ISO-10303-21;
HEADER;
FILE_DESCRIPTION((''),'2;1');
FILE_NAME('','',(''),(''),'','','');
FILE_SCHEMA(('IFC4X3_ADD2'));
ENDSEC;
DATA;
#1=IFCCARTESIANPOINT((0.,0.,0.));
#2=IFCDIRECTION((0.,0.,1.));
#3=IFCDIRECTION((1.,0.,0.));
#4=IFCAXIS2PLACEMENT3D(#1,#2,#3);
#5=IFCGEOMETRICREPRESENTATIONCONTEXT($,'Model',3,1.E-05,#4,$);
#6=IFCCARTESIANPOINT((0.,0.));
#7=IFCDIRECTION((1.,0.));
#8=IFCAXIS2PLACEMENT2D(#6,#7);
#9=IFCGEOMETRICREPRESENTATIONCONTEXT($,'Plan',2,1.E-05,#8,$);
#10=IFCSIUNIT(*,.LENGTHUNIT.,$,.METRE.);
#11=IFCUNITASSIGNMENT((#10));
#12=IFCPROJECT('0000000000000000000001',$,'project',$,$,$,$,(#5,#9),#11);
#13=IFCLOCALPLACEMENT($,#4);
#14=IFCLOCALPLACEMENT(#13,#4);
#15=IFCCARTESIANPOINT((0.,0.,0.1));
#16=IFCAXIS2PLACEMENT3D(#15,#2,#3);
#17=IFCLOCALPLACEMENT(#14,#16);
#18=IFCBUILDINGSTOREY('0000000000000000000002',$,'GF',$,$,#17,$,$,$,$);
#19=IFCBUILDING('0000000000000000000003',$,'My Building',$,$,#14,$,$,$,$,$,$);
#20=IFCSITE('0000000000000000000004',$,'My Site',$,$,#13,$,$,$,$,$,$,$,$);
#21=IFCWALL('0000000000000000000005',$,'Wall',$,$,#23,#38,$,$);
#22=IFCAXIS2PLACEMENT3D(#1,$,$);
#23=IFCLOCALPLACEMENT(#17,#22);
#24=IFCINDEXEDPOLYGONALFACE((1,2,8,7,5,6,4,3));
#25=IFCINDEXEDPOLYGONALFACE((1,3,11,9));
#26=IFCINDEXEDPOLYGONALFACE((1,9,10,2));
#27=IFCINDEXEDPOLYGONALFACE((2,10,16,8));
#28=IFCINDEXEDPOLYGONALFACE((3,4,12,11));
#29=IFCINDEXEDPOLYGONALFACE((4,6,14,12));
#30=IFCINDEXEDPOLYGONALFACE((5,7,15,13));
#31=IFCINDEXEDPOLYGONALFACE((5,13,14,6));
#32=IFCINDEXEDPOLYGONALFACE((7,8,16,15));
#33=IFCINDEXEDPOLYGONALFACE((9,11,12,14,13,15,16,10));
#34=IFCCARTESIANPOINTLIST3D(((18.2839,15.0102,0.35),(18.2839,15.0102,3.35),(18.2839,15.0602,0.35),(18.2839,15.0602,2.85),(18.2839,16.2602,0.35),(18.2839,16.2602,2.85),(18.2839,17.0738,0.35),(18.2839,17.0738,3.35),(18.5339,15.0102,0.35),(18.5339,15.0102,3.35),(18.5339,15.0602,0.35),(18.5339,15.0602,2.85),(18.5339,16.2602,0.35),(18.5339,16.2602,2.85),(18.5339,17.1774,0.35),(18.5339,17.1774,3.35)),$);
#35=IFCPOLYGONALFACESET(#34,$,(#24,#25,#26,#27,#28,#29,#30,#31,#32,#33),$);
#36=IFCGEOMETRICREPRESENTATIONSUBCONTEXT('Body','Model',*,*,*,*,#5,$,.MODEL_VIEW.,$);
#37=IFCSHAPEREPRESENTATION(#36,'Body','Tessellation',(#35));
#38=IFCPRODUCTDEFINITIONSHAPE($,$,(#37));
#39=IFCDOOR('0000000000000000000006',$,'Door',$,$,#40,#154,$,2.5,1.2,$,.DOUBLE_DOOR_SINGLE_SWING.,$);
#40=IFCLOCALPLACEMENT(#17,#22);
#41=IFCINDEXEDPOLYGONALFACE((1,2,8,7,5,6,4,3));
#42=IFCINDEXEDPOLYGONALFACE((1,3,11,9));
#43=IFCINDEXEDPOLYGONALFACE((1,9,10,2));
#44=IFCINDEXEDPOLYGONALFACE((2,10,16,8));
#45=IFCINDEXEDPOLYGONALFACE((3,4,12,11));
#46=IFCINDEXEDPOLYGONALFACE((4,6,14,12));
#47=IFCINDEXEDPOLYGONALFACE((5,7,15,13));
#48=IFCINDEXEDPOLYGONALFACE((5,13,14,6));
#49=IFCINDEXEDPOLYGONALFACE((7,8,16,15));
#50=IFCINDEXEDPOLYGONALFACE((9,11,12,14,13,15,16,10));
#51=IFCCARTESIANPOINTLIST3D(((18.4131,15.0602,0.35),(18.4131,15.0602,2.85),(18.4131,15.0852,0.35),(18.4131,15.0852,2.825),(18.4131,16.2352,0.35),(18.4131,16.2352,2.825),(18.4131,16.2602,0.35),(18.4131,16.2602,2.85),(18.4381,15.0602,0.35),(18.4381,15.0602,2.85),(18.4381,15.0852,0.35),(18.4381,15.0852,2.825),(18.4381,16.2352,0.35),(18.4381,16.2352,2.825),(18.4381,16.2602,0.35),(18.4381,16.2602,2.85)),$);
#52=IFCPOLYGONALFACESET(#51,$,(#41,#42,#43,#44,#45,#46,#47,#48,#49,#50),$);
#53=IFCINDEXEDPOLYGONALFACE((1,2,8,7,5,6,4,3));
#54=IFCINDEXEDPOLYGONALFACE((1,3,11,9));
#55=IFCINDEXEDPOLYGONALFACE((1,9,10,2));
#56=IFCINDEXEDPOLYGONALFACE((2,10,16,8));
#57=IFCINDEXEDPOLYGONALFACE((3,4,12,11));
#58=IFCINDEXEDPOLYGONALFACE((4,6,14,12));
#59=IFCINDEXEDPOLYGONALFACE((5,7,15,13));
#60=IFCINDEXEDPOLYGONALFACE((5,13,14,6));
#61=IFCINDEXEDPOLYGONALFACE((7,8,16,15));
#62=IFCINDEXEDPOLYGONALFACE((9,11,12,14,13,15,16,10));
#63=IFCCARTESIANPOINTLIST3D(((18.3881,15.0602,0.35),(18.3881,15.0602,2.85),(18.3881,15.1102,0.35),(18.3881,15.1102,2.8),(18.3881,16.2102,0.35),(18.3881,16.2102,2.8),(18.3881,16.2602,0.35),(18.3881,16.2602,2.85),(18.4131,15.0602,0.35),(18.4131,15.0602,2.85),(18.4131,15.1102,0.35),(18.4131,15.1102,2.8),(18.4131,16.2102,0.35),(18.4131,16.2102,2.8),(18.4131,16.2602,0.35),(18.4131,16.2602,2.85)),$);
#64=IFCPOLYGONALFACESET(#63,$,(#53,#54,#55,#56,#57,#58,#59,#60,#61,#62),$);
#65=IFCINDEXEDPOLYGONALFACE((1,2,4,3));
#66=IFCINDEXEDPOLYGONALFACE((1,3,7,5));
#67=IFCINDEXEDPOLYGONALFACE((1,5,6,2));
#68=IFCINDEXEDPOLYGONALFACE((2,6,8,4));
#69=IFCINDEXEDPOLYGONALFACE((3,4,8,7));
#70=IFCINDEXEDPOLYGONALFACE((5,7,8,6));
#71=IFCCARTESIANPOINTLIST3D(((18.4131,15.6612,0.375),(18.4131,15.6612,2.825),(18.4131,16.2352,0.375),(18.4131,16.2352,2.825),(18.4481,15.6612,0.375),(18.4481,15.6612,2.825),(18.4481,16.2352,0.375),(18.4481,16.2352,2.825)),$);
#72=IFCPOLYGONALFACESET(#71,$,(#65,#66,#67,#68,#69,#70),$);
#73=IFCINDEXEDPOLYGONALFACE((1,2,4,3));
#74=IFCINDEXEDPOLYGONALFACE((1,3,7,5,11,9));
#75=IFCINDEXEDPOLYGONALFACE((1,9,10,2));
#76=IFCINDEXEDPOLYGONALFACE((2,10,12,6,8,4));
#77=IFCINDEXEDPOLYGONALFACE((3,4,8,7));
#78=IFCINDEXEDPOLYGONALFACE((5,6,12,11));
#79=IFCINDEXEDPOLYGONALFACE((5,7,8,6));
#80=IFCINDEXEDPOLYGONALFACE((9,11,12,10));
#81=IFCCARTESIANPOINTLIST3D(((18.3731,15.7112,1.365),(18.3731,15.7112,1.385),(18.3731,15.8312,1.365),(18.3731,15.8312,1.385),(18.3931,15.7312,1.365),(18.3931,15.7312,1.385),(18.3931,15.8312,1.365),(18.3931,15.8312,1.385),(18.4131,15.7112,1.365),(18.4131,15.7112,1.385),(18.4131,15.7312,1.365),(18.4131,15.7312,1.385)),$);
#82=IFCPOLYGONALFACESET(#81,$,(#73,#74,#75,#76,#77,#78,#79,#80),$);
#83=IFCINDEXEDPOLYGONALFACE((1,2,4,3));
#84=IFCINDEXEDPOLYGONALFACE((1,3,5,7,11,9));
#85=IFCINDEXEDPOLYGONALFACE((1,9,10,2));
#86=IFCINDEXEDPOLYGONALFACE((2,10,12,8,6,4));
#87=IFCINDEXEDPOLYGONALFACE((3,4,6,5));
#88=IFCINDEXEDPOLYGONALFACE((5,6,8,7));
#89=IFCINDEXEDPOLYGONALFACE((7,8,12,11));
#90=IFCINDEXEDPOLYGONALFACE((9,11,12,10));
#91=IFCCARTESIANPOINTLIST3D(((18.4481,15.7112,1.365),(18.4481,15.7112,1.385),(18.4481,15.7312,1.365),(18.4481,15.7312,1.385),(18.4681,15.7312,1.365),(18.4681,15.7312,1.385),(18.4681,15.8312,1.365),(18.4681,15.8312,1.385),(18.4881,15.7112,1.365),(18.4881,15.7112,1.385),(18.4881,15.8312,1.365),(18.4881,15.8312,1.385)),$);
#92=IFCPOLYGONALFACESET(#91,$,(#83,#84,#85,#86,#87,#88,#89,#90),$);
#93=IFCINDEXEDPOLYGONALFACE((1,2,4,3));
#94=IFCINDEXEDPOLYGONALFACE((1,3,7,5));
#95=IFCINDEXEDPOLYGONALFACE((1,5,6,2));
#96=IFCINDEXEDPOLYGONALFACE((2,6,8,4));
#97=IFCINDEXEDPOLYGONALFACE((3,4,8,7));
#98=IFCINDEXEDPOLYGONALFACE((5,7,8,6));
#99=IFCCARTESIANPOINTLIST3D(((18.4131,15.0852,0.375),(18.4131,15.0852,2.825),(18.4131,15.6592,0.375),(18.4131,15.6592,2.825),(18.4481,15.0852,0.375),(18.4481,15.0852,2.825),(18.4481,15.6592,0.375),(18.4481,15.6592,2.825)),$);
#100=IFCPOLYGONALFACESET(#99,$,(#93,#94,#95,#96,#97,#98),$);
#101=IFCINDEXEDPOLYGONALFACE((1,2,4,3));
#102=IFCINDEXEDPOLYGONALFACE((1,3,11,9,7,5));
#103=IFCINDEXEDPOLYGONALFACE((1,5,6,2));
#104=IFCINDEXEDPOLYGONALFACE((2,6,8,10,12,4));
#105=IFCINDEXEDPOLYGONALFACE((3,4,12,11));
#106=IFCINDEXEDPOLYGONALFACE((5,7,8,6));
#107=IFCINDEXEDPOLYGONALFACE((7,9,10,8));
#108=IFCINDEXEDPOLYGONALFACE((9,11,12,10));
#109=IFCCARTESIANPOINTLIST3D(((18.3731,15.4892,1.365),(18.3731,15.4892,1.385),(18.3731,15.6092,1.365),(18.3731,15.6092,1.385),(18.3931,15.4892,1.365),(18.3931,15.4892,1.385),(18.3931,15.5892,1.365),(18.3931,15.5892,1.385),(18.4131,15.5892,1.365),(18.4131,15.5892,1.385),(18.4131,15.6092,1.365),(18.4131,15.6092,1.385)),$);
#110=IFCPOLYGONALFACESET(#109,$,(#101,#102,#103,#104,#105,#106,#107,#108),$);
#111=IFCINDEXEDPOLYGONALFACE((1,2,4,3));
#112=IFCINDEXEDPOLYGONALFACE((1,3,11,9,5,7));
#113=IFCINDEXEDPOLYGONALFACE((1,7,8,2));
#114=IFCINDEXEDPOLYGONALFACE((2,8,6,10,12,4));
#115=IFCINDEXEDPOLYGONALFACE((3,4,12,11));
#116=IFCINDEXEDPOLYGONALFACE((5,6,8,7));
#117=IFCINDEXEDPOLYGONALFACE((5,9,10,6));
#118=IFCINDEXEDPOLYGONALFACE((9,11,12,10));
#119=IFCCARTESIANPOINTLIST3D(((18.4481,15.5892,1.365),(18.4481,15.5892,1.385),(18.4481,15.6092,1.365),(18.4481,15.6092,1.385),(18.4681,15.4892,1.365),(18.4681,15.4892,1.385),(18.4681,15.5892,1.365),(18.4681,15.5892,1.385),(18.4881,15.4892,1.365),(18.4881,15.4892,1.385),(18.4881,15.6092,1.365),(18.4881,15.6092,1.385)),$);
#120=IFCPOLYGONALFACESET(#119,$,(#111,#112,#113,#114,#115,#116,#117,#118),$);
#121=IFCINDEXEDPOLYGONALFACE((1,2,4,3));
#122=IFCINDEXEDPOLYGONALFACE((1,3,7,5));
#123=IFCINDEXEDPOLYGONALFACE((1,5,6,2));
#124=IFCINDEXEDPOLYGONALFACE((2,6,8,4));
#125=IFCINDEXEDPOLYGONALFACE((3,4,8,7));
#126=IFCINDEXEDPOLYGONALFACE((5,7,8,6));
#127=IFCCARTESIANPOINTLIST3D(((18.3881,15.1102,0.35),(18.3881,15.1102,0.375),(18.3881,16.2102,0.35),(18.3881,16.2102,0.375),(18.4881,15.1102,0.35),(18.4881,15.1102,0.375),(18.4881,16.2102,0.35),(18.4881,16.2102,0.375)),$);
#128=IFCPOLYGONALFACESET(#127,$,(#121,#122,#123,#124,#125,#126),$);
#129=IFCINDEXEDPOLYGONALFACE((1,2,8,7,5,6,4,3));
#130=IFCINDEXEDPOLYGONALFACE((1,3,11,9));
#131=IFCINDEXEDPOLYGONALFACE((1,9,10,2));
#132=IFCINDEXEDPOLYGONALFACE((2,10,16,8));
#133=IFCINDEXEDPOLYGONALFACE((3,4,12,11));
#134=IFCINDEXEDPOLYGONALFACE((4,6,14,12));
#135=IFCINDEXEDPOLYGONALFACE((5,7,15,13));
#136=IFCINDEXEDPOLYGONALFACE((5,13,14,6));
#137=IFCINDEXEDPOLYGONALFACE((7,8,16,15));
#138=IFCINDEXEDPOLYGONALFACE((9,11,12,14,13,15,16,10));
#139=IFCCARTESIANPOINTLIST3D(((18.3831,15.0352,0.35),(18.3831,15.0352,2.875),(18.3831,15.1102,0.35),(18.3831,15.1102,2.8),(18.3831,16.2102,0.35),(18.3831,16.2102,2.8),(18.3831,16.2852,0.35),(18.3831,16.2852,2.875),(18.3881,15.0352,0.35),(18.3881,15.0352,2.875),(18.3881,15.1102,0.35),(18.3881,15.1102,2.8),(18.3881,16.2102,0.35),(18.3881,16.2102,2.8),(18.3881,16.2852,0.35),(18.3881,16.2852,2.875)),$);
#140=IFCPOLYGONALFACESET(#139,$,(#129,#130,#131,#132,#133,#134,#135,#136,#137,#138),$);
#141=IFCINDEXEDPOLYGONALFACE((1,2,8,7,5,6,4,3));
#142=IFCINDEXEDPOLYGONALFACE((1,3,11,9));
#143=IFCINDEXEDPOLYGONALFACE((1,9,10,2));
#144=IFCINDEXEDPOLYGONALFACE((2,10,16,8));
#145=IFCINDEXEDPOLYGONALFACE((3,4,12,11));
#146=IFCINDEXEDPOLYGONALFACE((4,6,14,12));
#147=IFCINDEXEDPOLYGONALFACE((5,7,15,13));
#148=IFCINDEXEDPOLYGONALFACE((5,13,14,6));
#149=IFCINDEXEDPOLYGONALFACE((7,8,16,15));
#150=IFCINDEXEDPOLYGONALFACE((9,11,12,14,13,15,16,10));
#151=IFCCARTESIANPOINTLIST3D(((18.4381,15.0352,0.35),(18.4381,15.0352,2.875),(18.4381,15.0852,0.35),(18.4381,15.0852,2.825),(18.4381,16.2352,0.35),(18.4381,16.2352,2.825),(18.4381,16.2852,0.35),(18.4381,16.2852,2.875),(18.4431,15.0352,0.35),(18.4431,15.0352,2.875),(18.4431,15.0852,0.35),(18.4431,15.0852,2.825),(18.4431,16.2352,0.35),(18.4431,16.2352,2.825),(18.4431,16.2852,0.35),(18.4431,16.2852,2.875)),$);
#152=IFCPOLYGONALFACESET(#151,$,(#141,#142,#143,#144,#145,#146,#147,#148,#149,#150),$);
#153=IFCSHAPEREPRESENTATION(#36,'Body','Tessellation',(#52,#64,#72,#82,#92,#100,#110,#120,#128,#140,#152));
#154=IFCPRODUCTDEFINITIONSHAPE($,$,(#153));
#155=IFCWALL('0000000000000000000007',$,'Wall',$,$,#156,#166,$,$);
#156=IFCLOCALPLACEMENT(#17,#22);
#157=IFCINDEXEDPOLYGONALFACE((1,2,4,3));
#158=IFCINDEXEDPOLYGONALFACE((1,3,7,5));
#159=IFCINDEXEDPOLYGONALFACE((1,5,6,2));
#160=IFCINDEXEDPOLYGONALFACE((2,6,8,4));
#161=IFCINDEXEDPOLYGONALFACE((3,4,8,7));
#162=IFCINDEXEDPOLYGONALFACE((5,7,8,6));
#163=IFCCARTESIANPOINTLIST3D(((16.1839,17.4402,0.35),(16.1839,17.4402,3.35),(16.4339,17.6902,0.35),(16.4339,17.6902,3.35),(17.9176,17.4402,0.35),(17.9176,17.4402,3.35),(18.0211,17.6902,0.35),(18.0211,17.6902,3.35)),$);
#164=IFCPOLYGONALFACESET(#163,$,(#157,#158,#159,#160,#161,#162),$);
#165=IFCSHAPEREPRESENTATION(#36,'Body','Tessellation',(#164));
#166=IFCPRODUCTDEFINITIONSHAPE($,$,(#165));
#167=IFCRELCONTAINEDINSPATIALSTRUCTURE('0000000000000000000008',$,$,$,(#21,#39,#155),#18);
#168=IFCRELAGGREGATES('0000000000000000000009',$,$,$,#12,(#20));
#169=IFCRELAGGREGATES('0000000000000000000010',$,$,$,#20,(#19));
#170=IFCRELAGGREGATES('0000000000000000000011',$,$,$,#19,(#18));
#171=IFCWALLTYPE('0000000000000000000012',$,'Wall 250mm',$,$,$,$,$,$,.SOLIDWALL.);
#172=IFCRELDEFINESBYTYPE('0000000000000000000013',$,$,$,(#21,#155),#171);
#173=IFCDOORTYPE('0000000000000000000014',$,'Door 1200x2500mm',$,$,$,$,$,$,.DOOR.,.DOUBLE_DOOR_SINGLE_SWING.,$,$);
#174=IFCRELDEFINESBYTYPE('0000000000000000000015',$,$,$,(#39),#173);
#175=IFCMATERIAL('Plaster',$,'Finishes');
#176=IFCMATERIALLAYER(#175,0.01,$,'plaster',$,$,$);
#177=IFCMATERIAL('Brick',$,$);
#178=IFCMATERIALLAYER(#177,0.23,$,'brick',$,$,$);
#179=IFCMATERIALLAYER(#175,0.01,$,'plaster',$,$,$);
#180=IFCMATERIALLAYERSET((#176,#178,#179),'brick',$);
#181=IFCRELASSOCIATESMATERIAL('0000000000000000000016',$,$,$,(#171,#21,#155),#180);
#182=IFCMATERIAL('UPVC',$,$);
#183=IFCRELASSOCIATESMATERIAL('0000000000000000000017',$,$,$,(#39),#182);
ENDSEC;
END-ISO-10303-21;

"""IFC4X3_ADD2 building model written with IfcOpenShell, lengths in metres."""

from ifc_helpers import new_model, entity, si_unit, frame, origin_with_axes, origin_2d_with_axis, place, context, subcontext, project, spatial, line, indexed_curve, outline, extrude, shape, source, transform, mapped, material, layer, layer_set, layer_usage, type_object, type_shapes, element, fill, save


model = new_model("IFC4X3_ADD2")

# Units and contexts
model_context = context("Model", 3, precision=1e-05, world=origin_with_axes())
plan_context = context("Plan", 2, precision=1e-05, world=origin_2d_with_axis())
body_context_1 = subcontext(model_context, "Body", "Model", "MODEL_VIEW")
body_context_2 = subcontext(plan_context, "Body", "Plan", "PLAN_VIEW")
ifc_project = project(units=[si_unit("LENGTHUNIT", "METRE")], contexts=[model_context, plan_context])

# Site, building, storey
site_placement = place(None, origin_with_axes())
site = spatial("IfcSite", under=ifc_project, at=site_placement, Name="My Site")
building_placement = place(site_placement, origin_with_axes())
building = spatial("IfcBuilding", under=site, at=building_placement, Name="My Building")
storey_placement = place(building_placement, frame((0.0, 0.0, 0.1), z_axis=(0.0, 0.0, 1.0), x_axis=(1.0, 0.0, 0.0)))
storey = spatial("IfcBuildingStorey", under=building, at=storey_placement, Name="GF")

# Shared definitions
ifc_material_1 = material(Name="UPVC")

# Shared definitions
ifc_material_2 = material(Name="Plaster", Category="Finishes")
ifc_layer_1 = layer(ifc_material_2, 0.01, Name="plaster")
ifc_material_3 = material(Name="Brick")
ifc_layer_2 = layer(ifc_material_3, 0.23, Name="brick")
ifc_layer_3 = layer(ifc_material_2, 0.01, Name="plaster")
ifc_layer_set_1 = layer_set([ifc_layer_1, ifc_layer_2, ifc_layer_3], Name="brick")
wall_type_1 = type_object("IfcWallType", Name="Wall 250mm", PredefinedType="SOLIDWALL", material=ifc_layer_set_1)

# Wall, opening, door
ifc_layer_usage_1 = layer_usage(ifc_layer_set_1, "AXIS2", "NEGATIVE", 0.0)
wall_1_placement = place(storey_placement, frame((18.2839, 15.0102, 0.35), z_axis=(0.0, 0.0, 1.0), x_axis=(0.000001, 1.0, 0.0)))
wall_1 = element("IfcWall", 1, at=wall_1_placement, inside=storey, type_object=wall_type_1, material=ifc_layer_usage_1, Name="Wall", context=body_context_1, shape_type="SweptSolid", body=[
    extrude(outline(indexed_curve([(0.0, -0.25), (0.0, 0.0), (2.0636, 0.0), (2.1672, -0.25)], segments=[line(1, 2, 3, 4, 1)])), origin_with_axes(), (0.0, 0.0, 1.0), 3.0),
])
shared_shape_1 = source(origin_with_axes(), body_context_1, "Body", "SweptSolid", [
    extrude(outline(indexed_curve([(0.0, 0.0), (1.2, 0.0), (1.2, 2.5), (0.0, 2.5)], segments=[line(1, 2, 3, 4, 1)])), frame((0.0, -0.6, 0.0), z_axis=(0.0, -1.0, 0.0), x_axis=(1.0, 0.0, 0.0)), (0.0, 0.0, -1.0), 1.2),
])
opening_1_placement = place(wall_1_placement, frame((1.25, 0.1258, 0.0), z_axis=(0.0, 0.0, 1.0), x_axis=(-1.0, 0.0, 0.0)))
opening_1 = element("IfcOpeningElement", 2, at=opening_1_placement, cuts=wall_1, PredefinedType="OPENING", context=body_context_1, shape_type="MappedRepresentation", body=[
    mapped(shared_shape_1, transform((0.0, 0.0, 0.0), x_axis=(1.0, 0.0, 0.0), y_axis=(0.0, 1.0, 0.0), z_axis=(0.0, 0.0, 1.0), scale=1.0)),
])
door_type_1 = type_object("IfcDoorType", Name="Door 1200x2500mm", OperationType="DOUBLE_DOOR_SINGLE_SWING", PredefinedType="DOOR")
shared_shape_2 = source(origin_with_axes(), body_context_1, "Body", "SweptSolid", [
    extrude(outline(indexed_curve([(0.0, 0.0), (0.0, 2.5), (1.2, 2.5), (1.2, 0.0), (1.175, 0.0), (1.175, 2.475), (0.025, 2.475), (0.025, 0.0)], segments=[line(1, 2, 3, 4, 5, 6, 7, 8, 1)])), frame((0.0, 0.025, 0.0), z_axis=(0.0, -1.0, 0.0), x_axis=(1.0, 0.0, 0.0)), (0.0, 0.0, -1.0), 0.025),
    extrude(outline(indexed_curve([(0.0, 0.0), (0.0, 2.5), (1.2, 2.5), (1.2, 0.0), (1.15, 0.0), (1.15, 2.45), (0.05, 2.45), (0.05, 0.0)], segments=[line(1, 2, 3, 4, 5, 6, 7, 8, 1)])), frame((0.0, 0.0, 0.0), z_axis=(0.0, -1.0, 0.0), x_axis=(1.0, 0.0, 0.0)), (0.0, 0.0, -1.0), 0.025),
    extrude(outline(indexed_curve([(0.0, 0.0), (0.574, 0.0), (0.574, 0.035), (0.0, 0.035)], segments=[line(1, 2, 3, 4, 1)])), frame((0.025, 0.025, 0.025), z_axis=(0.0, 0.0, 1.0), x_axis=(1.0, 0.0, 0.0)), (0.0, 0.0, 1.0), 2.45),
    extrude(outline(indexed_curve([(0.0, 0.0), (0.0, -0.04), (-0.12, -0.04), (-0.12, -0.02), (-0.02, -0.02), (-0.02, 0.0)], segments=[line(1, 2, 3, 4, 5, 6, 1)])), frame((0.549, 0.025, 1.015), z_axis=(0.0, 0.0, 1.0), x_axis=(1.0, 0.0, 0.0)), (0.0, 0.0, 1.0), 0.02),
    extrude(outline(indexed_curve([(0.0, 0.0), (0.0, 0.04), (-0.12, 0.04), (-0.12, 0.02), (-0.02, 0.02), (-0.02, 0.0)], segments=[line(1, 2, 3, 4, 5, 6, 1)])), frame((0.549, 0.06, 1.015), z_axis=(0.0, 0.0, 1.0), x_axis=(1.0, 0.0, 0.0)), (0.0, 0.0, 1.0), 0.02),
    extrude(outline(indexed_curve([(0.0, 0.0), (-0.574, 0.0), (-0.574, 0.035), (0.0, 0.035)], segments=[line(1, 2, 3, 4, 1)])), frame((1.175, 0.025, 0.025), z_axis=(0.0, 0.0, 1.0), x_axis=(1.0, 0.0, 0.0)), (0.0, 0.0, 1.0), 2.45),
    extrude(outline(indexed_curve([(0.0, 0.0), (0.0, -0.04), (0.12, -0.04), (0.12, -0.02), (0.02, -0.02), (0.02, 0.0)], segments=[line(1, 2, 3, 4, 5, 6, 1)])), frame((0.651, 0.025, 1.015), z_axis=(0.0, 0.0, 1.0), x_axis=(1.0, 0.0, 0.0)), (0.0, 0.0, 1.0), 0.02),
    extrude(outline(indexed_curve([(0.0, 0.0), (0.0, 0.04), (0.12, 0.04), (0.12, 0.02), (0.02, 0.02), (0.02, 0.0)], segments=[line(1, 2, 3, 4, 5, 6, 1)])), frame((0.651, 0.06, 1.015), z_axis=(0.0, 0.0, 1.0), x_axis=(1.0, 0.0, 0.0)), (0.0, 0.0, 1.0), 0.02),
    extrude(outline(indexed_curve([(0.0, 0.0), (1.1, 0.0), (1.1, 0.1), (0.0, 0.1)], segments=[line(1, 2, 3, 4, 1)])), frame((0.05, 0.0, 0.0), z_axis=(0.0, 0.0, 1.0), x_axis=(1.0, 0.0, 0.0)), (0.0, 0.0, 1.0), 0.025),
    extrude(outline(indexed_curve([(0.0, 0.0), (0.0, 2.525), (1.25, 2.525), (1.25, 0.0), (1.175, 0.0), (1.175, 2.45), (0.075, 2.45), (0.075, 0.0)], segments=[line(1, 2, 3, 4, 5, 6, 7, 8, 1)])), frame((-0.025, -0.005, 0.0), z_axis=(0.0, -1.0, 0.0), x_axis=(1.0, 0.0, 0.0)), (0.0, 0.0, -1.0), 0.005),
    extrude(outline(indexed_curve([(0.0, 0.0), (0.0, 2.525), (1.25, 2.525), (1.25, 0.0), (1.2, 0.0), (1.2, 2.475), (0.05, 2.475), (0.05, 0.0)], segments=[line(1, 2, 3, 4, 5, 6, 7, 8, 1)])), frame((-0.025, 0.05, 0.0), z_axis=(0.0, -1.0, 0.0), x_axis=(1.0, 0.0, 0.0)), (0.0, 0.0, -1.0), 0.005),
])
shared_shape_3 = source(origin_with_axes(), body_context_2, "Body", "Curve2D", [
    entity("IfcIndexedPolyCurve", entity("IfcCartesianPointList2D", [[0.0, 0.0], [0.0, 0.05], [0.025, 0.05], [0.025, 0.025], [0.05, 0.025], [0.05, 0.0]]), [entity("IfcLineIndex", [1, 2, 3, 4, 5, 6, 1])]),
    entity("IfcIndexedPolyCurve", entity("IfcCartesianPointList2D", [[1.2, 0.0], [1.2, 0.05], [1.175, 0.05], [1.175, 0.025], [1.15, 0.025], [1.15, 0.0]]), [entity("IfcLineIndex", [1, 2, 3, 4, 5, 6, 1])]),
    entity("IfcTrimmedCurve", entity("IfcEllipse", entity("IfcAxis2Placement2D", entity("IfcCartesianPoint", [0.06, 0.05]), entity("IfcDirection", [1.0, 0.0])), 0.54, 0.575), [entity("IfcCartesianPoint", [0.6, 0.05])], [entity("IfcCartesianPoint", [0.06, 0.625])], True, "CARTESIAN"),
    entity("IfcIndexedPolyCurve", entity("IfcCartesianPointList2D", [[0.025, 0.05], [0.06, 0.05], [0.06, 0.625], [0.025, 0.625]]), [entity("IfcLineIndex", [1, 2, 3, 4, 1])]),
    entity("IfcTrimmedCurve", entity("IfcEllipse", entity("IfcAxis2Placement2D", entity("IfcCartesianPoint", [1.14, 0.05]), entity("IfcDirection", [1.0, 0.0])), 0.54, 0.575), [entity("IfcCartesianPoint", [1.14, 0.625])], [entity("IfcCartesianPoint", [0.6, 0.05])], True, "CARTESIAN"),
    entity("IfcIndexedPolyCurve", entity("IfcCartesianPointList2D", [[1.175, 0.05], [1.14, 0.05], [1.14, 0.625], [1.175, 0.625]]), [entity("IfcLineIndex", [1, 2, 3, 4, 1])]),
])
type_shapes(door_type_1, [shared_shape_2, shared_shape_3])
door_1_placement = place(opening_1_placement, frame((0.0, 0.23, 0.0), z_axis=(0.0, 0.0, 1.0), x_axis=(1.0, 0.0, 0.0)))
door_1 = element("IfcDoor", 3, at=door_1_placement, inside=storey, type_object=door_type_1, material=ifc_material_1, Name="Door", OperationType="DOUBLE_DOOR_SINGLE_SWING", OverallHeight=2.5, OverallWidth=1.2, shapes=[
    shape(body_context_1, "Body", "MappedRepresentation", [mapped(shared_shape_2, transform((0.0, 0.0, 0.0), x_axis=(1.0, 0.0, 0.0), y_axis=(0.0, 1.0, 0.0), z_axis=(0.0, 0.0, 1.0), scale=1.0))]),
    shape(body_context_2, "Body", "MappedRepresentation", [mapped(shared_shape_3, transform((0.0, 0.0, 0.0), x_axis=(1.0, 0.0, 0.0), y_axis=(0.0, 1.0, 0.0), z_axis=(0.0, 0.0, 1.0), scale=1.0))]),
])
fill(opening_1, door_1)

# Wall
ifc_layer_usage_2 = layer_usage(ifc_layer_set_1, "AXIS2", "NEGATIVE", 0.0)
wall_2_placement = place(storey_placement, frame((17.9176, 17.4402, 0.35), z_axis=(0.0, 0.0, 1.0), x_axis=(-1.0, 0.0, 0.0)))
element("IfcWall", 4, at=wall_2_placement, inside=storey, type_object=wall_type_1, material=ifc_layer_usage_2, Name="Wall", context=body_context_1, shape_type="SweptSolid", body=[
    extrude(outline(indexed_curve([(-0.1036, -0.25), (0.0, 0.0), (1.7336, 0.0), (1.4836, -0.25)], segments=[line(1, 2, 3, 4, 1)])), origin_with_axes(), (0.0, 0.0, 1.0), 3.0),
])

save(model, "model.ifc")
